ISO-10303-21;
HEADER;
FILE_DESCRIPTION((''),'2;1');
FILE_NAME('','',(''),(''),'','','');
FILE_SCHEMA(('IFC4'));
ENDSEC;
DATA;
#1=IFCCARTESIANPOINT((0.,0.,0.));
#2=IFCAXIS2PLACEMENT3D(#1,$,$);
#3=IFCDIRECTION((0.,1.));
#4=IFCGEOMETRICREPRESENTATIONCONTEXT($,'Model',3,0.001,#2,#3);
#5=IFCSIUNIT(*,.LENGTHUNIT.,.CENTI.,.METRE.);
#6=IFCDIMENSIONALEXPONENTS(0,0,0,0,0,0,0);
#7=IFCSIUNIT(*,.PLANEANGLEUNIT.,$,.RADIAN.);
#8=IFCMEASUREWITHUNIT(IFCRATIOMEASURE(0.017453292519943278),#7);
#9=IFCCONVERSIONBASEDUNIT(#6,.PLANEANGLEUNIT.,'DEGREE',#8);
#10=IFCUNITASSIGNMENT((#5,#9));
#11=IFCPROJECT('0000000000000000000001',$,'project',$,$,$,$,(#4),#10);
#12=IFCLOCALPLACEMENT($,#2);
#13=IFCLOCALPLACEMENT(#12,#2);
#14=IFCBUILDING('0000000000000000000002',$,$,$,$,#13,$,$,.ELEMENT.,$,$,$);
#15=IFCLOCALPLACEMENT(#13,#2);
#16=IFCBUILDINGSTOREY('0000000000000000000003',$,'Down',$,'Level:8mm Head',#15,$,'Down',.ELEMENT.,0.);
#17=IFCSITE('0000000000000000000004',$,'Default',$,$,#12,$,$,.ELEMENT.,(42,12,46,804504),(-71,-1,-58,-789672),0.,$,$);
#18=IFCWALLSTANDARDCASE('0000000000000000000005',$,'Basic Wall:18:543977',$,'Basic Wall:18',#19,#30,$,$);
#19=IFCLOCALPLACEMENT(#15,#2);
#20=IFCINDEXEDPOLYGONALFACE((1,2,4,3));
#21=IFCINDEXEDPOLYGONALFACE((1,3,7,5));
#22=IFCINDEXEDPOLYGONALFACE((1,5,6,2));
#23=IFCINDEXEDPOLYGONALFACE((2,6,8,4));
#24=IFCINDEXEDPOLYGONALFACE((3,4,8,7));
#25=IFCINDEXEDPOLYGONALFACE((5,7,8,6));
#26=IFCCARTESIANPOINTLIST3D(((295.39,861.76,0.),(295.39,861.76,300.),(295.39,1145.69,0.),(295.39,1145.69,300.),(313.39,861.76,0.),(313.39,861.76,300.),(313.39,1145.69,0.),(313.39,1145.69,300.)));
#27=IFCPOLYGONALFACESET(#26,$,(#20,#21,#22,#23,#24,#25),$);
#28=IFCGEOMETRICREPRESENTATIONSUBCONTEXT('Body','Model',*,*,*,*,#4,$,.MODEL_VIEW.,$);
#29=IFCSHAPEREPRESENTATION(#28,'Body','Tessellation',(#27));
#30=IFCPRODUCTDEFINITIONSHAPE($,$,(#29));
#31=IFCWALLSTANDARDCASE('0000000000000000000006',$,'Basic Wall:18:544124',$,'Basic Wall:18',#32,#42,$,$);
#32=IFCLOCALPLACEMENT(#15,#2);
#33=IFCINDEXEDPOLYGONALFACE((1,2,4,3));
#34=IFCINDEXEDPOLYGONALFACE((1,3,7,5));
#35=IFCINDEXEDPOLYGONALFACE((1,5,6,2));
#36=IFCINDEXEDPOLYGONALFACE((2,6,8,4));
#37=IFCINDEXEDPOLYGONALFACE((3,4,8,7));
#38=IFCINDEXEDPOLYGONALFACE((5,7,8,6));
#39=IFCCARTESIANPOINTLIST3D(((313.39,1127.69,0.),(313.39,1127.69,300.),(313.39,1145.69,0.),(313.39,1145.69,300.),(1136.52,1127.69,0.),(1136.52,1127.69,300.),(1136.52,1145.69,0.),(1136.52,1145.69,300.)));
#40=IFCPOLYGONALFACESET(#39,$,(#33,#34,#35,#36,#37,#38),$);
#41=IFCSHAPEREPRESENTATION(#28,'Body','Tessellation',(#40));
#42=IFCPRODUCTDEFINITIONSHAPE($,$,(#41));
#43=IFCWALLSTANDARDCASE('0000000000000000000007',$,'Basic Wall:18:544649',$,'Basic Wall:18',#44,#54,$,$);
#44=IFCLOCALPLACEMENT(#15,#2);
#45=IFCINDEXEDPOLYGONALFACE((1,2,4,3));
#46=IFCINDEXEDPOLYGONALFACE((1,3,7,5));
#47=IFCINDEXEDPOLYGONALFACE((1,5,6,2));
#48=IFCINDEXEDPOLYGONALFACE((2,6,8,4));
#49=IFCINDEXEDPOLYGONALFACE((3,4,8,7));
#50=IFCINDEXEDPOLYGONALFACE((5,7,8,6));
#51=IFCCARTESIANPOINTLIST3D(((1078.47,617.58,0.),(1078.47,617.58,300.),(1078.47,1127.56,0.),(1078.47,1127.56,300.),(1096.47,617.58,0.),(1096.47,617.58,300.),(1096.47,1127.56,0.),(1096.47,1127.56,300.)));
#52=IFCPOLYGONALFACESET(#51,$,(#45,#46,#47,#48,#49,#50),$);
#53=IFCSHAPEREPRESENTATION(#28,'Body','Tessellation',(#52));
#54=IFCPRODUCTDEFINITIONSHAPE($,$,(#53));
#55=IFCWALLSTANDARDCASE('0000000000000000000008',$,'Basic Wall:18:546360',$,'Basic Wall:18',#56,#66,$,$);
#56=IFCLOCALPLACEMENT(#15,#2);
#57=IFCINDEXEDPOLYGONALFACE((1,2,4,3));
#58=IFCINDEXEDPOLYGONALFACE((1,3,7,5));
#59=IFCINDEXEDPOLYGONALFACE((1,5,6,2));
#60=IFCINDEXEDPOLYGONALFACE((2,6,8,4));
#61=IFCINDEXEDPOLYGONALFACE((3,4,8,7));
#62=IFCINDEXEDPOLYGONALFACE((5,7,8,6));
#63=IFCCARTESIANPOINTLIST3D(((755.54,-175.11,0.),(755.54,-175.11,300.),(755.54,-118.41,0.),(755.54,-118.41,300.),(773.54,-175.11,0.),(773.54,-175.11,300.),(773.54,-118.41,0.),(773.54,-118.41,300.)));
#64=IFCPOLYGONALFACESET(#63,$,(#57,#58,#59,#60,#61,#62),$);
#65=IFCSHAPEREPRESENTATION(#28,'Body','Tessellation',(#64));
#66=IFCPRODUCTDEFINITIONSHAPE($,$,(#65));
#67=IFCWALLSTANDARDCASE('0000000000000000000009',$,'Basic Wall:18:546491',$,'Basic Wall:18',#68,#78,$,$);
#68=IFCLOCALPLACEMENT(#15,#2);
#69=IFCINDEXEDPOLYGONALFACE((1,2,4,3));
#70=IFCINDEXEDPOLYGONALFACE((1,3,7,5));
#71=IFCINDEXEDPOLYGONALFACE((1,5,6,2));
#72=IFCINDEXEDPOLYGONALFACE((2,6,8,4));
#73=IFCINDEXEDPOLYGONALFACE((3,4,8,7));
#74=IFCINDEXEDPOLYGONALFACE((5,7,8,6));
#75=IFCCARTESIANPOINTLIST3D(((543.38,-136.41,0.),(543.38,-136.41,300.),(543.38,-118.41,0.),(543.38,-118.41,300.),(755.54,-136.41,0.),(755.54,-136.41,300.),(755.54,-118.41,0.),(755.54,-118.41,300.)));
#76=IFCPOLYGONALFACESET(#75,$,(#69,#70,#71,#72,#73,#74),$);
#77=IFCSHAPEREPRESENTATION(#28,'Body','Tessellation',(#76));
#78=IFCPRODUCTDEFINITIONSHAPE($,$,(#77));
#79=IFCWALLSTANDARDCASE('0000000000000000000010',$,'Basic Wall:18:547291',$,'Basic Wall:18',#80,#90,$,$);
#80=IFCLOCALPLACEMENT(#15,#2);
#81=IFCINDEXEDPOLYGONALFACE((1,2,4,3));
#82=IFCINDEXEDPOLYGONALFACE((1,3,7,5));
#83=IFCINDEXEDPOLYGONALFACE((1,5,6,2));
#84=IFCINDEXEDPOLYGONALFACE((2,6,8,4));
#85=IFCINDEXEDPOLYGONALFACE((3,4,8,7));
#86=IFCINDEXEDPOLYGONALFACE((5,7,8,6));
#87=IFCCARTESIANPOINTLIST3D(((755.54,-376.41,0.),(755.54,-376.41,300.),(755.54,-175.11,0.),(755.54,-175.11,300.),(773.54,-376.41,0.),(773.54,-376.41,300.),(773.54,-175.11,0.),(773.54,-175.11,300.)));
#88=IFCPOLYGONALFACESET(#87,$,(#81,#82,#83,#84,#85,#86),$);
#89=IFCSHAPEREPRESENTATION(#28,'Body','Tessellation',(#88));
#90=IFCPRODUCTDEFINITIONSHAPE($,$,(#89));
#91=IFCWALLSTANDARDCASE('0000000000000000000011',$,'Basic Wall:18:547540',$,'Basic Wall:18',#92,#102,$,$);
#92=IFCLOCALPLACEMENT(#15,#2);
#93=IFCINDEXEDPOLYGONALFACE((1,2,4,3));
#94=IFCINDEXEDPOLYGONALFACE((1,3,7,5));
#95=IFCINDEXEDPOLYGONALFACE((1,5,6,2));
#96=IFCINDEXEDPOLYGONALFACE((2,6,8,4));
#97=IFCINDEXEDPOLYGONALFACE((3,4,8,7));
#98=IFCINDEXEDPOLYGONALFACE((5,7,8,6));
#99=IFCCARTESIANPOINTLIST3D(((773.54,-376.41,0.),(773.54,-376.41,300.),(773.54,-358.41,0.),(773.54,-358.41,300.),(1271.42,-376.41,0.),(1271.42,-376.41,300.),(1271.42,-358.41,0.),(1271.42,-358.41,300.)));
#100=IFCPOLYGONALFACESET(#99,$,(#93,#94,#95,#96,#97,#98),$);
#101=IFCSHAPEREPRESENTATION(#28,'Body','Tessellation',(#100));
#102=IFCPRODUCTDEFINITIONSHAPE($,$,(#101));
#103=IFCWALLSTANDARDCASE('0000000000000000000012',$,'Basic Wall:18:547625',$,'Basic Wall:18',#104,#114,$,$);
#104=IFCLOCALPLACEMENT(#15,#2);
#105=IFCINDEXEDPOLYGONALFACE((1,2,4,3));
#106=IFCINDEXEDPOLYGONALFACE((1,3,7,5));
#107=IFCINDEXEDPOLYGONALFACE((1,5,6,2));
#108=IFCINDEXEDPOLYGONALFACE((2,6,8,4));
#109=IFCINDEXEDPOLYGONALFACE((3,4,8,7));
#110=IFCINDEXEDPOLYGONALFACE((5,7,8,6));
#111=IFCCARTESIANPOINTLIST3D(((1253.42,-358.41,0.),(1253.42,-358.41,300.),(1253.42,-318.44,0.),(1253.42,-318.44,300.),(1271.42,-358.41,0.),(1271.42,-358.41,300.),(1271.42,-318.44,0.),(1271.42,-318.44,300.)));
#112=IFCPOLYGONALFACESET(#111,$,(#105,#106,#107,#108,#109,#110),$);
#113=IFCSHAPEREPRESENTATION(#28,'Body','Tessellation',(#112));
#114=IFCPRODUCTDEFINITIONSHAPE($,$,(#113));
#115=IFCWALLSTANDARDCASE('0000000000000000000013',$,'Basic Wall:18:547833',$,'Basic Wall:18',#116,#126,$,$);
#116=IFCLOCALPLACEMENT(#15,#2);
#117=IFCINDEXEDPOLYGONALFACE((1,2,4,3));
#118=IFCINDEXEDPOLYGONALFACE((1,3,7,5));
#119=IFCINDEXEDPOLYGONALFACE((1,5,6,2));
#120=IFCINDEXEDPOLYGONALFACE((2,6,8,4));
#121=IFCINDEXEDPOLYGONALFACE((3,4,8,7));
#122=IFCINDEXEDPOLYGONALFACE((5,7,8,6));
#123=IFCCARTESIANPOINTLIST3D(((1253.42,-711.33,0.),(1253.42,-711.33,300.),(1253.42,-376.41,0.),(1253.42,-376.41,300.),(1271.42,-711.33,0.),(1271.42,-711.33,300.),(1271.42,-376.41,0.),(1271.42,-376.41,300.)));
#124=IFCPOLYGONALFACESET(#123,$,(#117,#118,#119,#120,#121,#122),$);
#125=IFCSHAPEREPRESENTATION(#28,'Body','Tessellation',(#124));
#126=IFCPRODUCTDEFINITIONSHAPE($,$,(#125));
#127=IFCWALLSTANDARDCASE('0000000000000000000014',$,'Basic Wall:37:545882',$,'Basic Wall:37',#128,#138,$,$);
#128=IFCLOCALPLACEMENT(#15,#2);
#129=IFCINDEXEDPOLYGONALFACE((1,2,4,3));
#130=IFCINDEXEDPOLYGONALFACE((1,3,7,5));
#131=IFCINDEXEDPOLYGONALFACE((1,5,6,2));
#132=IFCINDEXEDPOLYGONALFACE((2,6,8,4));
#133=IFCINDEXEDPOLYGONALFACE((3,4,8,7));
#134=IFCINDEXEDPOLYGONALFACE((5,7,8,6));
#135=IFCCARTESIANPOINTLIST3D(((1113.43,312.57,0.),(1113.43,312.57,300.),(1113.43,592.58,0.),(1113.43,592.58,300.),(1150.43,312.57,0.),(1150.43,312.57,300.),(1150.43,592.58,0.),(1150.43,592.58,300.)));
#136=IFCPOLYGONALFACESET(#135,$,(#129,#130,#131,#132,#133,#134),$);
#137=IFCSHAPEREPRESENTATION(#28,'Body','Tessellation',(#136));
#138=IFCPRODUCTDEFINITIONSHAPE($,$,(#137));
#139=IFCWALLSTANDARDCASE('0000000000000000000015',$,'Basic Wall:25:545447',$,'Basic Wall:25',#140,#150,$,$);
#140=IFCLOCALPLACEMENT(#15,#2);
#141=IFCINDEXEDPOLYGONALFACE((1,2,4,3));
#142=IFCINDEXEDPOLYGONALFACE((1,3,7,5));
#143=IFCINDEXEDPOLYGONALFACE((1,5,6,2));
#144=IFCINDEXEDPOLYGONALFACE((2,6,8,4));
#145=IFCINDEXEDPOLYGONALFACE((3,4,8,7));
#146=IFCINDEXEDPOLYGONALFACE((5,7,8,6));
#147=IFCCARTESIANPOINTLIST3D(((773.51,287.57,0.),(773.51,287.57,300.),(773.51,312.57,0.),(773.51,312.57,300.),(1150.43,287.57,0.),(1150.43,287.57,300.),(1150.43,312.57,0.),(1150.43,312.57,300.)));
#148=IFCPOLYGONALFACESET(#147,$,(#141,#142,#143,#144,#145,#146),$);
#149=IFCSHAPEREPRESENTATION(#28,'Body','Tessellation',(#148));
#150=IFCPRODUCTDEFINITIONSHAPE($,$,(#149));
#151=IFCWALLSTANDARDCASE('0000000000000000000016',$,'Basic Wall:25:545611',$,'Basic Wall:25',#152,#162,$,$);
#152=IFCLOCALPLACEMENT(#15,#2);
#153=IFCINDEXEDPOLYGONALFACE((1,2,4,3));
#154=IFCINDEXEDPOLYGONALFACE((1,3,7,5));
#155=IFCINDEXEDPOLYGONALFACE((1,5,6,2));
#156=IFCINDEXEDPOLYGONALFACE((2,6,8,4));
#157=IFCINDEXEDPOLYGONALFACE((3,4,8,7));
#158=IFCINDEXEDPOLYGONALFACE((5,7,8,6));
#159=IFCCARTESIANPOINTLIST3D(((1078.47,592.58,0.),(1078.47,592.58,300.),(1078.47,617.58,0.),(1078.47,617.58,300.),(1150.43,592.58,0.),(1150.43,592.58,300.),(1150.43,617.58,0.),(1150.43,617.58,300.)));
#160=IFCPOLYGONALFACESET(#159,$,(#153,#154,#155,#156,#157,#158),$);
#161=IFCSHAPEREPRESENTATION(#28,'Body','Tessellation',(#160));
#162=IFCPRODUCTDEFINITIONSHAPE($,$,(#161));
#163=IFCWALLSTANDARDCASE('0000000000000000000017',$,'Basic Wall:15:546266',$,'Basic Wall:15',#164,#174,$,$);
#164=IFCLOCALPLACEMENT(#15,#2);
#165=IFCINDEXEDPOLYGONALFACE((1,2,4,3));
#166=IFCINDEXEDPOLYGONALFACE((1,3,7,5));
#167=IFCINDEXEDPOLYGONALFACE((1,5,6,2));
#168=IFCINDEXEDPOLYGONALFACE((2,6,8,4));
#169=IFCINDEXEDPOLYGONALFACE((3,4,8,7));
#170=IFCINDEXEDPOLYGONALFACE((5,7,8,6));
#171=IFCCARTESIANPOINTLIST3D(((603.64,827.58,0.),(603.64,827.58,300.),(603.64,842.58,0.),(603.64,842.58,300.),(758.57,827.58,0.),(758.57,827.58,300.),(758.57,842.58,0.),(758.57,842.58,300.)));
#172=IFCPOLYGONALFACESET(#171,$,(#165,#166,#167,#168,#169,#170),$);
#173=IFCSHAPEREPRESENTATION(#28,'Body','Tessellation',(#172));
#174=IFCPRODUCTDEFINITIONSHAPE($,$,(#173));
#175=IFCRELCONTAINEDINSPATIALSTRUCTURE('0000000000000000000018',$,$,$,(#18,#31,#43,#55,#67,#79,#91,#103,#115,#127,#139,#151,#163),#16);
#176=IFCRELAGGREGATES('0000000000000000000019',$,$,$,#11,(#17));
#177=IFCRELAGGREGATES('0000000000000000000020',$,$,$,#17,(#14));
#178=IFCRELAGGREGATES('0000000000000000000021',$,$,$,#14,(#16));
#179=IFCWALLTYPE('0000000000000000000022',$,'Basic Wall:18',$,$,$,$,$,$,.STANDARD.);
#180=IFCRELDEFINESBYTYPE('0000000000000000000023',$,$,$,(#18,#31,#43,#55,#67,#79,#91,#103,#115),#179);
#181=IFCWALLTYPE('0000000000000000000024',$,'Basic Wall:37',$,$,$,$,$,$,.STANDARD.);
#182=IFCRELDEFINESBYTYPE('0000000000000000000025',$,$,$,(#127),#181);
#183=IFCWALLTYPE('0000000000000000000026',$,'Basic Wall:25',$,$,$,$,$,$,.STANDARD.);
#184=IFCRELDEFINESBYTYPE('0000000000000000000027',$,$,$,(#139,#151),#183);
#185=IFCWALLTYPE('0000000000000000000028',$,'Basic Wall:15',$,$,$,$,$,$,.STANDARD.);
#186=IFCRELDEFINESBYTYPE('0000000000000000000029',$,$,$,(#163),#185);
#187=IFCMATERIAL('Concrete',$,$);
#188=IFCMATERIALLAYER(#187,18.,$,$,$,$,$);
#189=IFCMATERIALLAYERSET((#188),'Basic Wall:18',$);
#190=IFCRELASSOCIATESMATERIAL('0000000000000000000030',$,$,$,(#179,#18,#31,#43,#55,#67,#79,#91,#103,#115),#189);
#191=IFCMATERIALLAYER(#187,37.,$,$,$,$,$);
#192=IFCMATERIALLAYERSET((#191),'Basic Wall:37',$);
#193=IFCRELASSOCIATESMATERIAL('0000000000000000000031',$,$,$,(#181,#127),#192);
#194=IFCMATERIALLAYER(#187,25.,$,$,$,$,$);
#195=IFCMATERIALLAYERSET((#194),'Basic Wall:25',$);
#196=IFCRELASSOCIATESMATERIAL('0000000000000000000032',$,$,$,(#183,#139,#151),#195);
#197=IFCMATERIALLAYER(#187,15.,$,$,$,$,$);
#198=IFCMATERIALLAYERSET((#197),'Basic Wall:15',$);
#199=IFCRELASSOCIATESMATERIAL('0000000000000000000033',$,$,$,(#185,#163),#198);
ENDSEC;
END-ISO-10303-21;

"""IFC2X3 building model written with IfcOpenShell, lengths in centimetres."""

from ifc_helpers import new_model, entity, si_unit, converted_unit, direction, frame, frame_2d, origin, place, context, subcontext, project, spatial, rectangle, extrude, material, layer, layer_set, layer_usage, type_object, element, save


model = new_model("IFC2X3")

# Units and contexts
model_context = context("Model", 3, precision=0.001, world=origin(), true_north=direction((0.0, 1.0)))
body_context = subcontext(model_context, "Body", "Model", "MODEL_VIEW")
ifc_project = project(units=[si_unit("LENGTHUNIT", "METRE", prefix="CENTI"), converted_unit("PLANEANGLEUNIT", "DEGREE", entity("IfcRatioMeasure", 0.017453292519943278), si_unit("PLANEANGLEUNIT", "RADIAN"), dimensions=[0, 0, 0, 0, 0, 0, 0])], contexts=[model_context])

# Site, building, storey
site_placement = place(None, origin())
site = spatial("IfcSite", under=ifc_project, at=site_placement, Name="Default", CompositionType="ELEMENT", RefLatitude=(42, 12, 46, 804504), RefLongitude=(-71, -1, -58, -789672), RefElevation=0.0)
building_placement = place(site_placement, origin())
building = spatial("IfcBuilding", under=site, at=building_placement, CompositionType="ELEMENT")
storey_placement = place(building_placement, origin())
storey = spatial("IfcBuildingStorey", under=building, at=storey_placement, Name="Down", ObjectType="Level:8mm Head", LongName="Down", CompositionType="ELEMENT", Elevation=0.0)

# Walls
ifc_material = material(Name="Concrete")
ifc_layer_1 = layer(ifc_material, 18.0)
ifc_layer_set_1 = layer_set([ifc_layer_1], Name="Basic Wall:18")
wall_type_1 = type_object("IfcWallType", Name="Basic Wall:18", PredefinedType="STANDARD", material=ifc_layer_set_1)
ifc_layer_usage_1 = layer_usage(ifc_layer_set_1, "AXIS2", "POSITIVE", -9.0)
wall_1_placement = place(storey_placement, frame((304.39, 861.76, 0.0), z_axis=(0.0, 0.0, 1.0), x_axis=(0.0, 1.0, 0.0)))
element("IfcWallStandardCase", 1, at=wall_1_placement, inside=storey, type_object=wall_type_1, material=ifc_layer_usage_1, Name="Basic Wall:18:543977", ObjectType="Basic Wall:18", context=body_context, shape_type="SweptSolid", body=[
    extrude(rectangle(XDim=283.93, YDim=18.0, at=frame_2d((141.97, 0.0), x_axis=(-1.0, 0.0))), origin(), (0.0, 0.0, 1.0), 300.0),
])
ifc_layer_usage_2 = layer_usage(ifc_layer_set_1, "AXIS2", "NEGATIVE", 9.0)
wall_2_placement = place(storey_placement, frame((313.39, 1136.69, 0.0)))
element("IfcWallStandardCase", 2, at=wall_2_placement, inside=storey, type_object=wall_type_1, material=ifc_layer_usage_2, Name="Basic Wall:18:544124", ObjectType="Basic Wall:18", context=body_context, shape_type="SweptSolid", body=[
    extrude(rectangle(XDim=823.13, YDim=18.0, at=frame_2d((411.56, 0.0), x_axis=(-1.0, 0.0))), origin(), (0.0, 0.0, 1.0), 300.0),
])
ifc_layer_usage_3 = layer_usage(ifc_layer_set_1, "AXIS2", "NEGATIVE", 9.0)
wall_3_placement = place(storey_placement, frame((1087.47, 1127.56, 0.0), z_axis=(0.0, 0.0, 1.0), x_axis=(0.0, -1.0, 0.0)))
element("IfcWallStandardCase", 3, at=wall_3_placement, inside=storey, type_object=wall_type_1, material=ifc_layer_usage_3, Name="Basic Wall:18:544649", ObjectType="Basic Wall:18", context=body_context, shape_type="SweptSolid", body=[
    extrude(rectangle(XDim=509.98, YDim=18.0, at=frame_2d((254.99, 0.0), x_axis=(-1.0, 0.0))), origin(), (0.0, 0.0, 1.0), 300.0),
])
ifc_layer_usage_4 = layer_usage(ifc_layer_set_1, "AXIS2", "POSITIVE", -9.0)
wall_4_placement = place(storey_placement, frame((764.54, -175.11, 0.0), z_axis=(0.0, 0.0, 1.0), x_axis=(0.0, 1.0, 0.0)))
element("IfcWallStandardCase", 4, at=wall_4_placement, inside=storey, type_object=wall_type_1, material=ifc_layer_usage_4, Name="Basic Wall:18:546360", ObjectType="Basic Wall:18", context=body_context, shape_type="SweptSolid", body=[
    extrude(rectangle(XDim=56.7, YDim=18.0, at=frame_2d((28.35, 0.0), x_axis=(-1.0, 0.0))), origin(), (0.0, 0.0, 1.0), 300.0),
])
ifc_layer_usage_5 = layer_usage(ifc_layer_set_1, "AXIS2", "POSITIVE", -9.0)
wall_5_placement = place(storey_placement, frame((755.54, -127.41, 0.0), z_axis=(0.0, 0.0, 1.0), x_axis=(-1.0, 0.0, 0.0)))
element("IfcWallStandardCase", 5, at=wall_5_placement, inside=storey, type_object=wall_type_1, material=ifc_layer_usage_5, Name="Basic Wall:18:546491", ObjectType="Basic Wall:18", context=body_context, shape_type="SweptSolid", body=[
    extrude(rectangle(XDim=212.16, YDim=18.0, at=frame_2d((106.08, 0.0), x_axis=(-1.0, 0.0))), origin(), (0.0, 0.0, 1.0), 300.0),
])
ifc_layer_usage_6 = layer_usage(ifc_layer_set_1, "AXIS2", "NEGATIVE", 9.0)
wall_6_placement = place(storey_placement, frame((764.54, -175.11, 0.0), z_axis=(0.0, 0.0, 1.0), x_axis=(0.0, -1.0, 0.0)))
element("IfcWallStandardCase", 6, at=wall_6_placement, inside=storey, type_object=wall_type_1, material=ifc_layer_usage_6, Name="Basic Wall:18:547291", ObjectType="Basic Wall:18", context=body_context, shape_type="SweptSolid", body=[
    extrude(rectangle(XDim=201.3, YDim=18.0, at=frame_2d((100.65, 0.0), x_axis=(-1.0, 0.0))), origin(), (0.0, 0.0, 1.0), 300.0),
])
ifc_layer_usage_7 = layer_usage(ifc_layer_set_1, "AXIS2", "POSITIVE", -9.0)
wall_7_placement = place(storey_placement, frame((773.54, -367.41, 0.0)))
element("IfcWallStandardCase", 7, at=wall_7_placement, inside=storey, type_object=wall_type_1, material=ifc_layer_usage_7, Name="Basic Wall:18:547540", ObjectType="Basic Wall:18", context=body_context, shape_type="SweptSolid", body=[
    extrude(rectangle(XDim=497.88, YDim=18.0, at=frame_2d((248.94, 0.0), x_axis=(-1.0, 0.0))), origin(), (0.0, 0.0, 1.0), 300.0),
])
ifc_layer_usage_8 = layer_usage(ifc_layer_set_1, "AXIS2", "POSITIVE", -9.0)
wall_8_placement = place(storey_placement, frame((1262.42, -358.41, 0.0), z_axis=(0.0, 0.0, 1.0), x_axis=(0.0, 1.0, 0.0)))
element("IfcWallStandardCase", 8, at=wall_8_placement, inside=storey, type_object=wall_type_1, material=ifc_layer_usage_8, Name="Basic Wall:18:547625", ObjectType="Basic Wall:18", context=body_context, shape_type="SweptSolid", body=[
    extrude(rectangle(XDim=39.97, YDim=18.0, at=frame_2d((19.98, 0.0), x_axis=(-1.0, 0.0))), origin(), (0.0, 0.0, 1.0), 300.0),
])
ifc_layer_usage_9 = layer_usage(ifc_layer_set_1, "AXIS2", "NEGATIVE", 9.0)
wall_9_placement = place(storey_placement, frame((1262.42, -376.41, 0.0), z_axis=(0.0, 0.0, 1.0), x_axis=(0.0, -1.0, 0.0)))
element("IfcWallStandardCase", 9, at=wall_9_placement, inside=storey, type_object=wall_type_1, material=ifc_layer_usage_9, Name="Basic Wall:18:547833", ObjectType="Basic Wall:18", context=body_context, shape_type="SweptSolid", body=[
    extrude(rectangle(XDim=334.92, YDim=18.0, at=frame_2d((167.46, 0.0), x_axis=(-1.0, 0.0))), origin(), (0.0, 0.0, 1.0), 300.0),
])
ifc_layer_2 = layer(ifc_material, 37.0)
ifc_layer_set_2 = layer_set([ifc_layer_2], Name="Basic Wall:37")
ifc_layer_usage_10 = layer_usage(ifc_layer_set_2, "AXIS2", "NEGATIVE", 18.5)
wall_type_2 = type_object("IfcWallType", Name="Basic Wall:37", PredefinedType="STANDARD", material=ifc_layer_set_2)
wall_10_placement = place(storey_placement, frame((1131.93, 592.58, 0.0), z_axis=(0.0, 0.0, 1.0), x_axis=(0.0, -1.0, 0.0)))
element("IfcWallStandardCase", 10, at=wall_10_placement, inside=storey, type_object=wall_type_2, material=ifc_layer_usage_10, Name="Basic Wall:37:545882", ObjectType="Basic Wall:37", context=body_context, shape_type="SweptSolid", body=[
    extrude(rectangle(XDim=280.01, YDim=37.0, at=frame_2d((140.01, 0.0), x_axis=(-1.0, 0.0))), origin(), (0.0, 0.0, 1.0), 300.0),
])
ifc_layer_3 = layer(ifc_material, 25.0)
ifc_layer_set_3 = layer_set([ifc_layer_3], Name="Basic Wall:25")
ifc_layer_usage_11 = layer_usage(ifc_layer_set_3, "AXIS2", "POSITIVE", -12.5)
wall_type_3 = type_object("IfcWallType", Name="Basic Wall:25", PredefinedType="STANDARD", material=ifc_layer_set_3)
wall_11_placement = place(storey_placement, frame((773.51, 300.07, 0.0)))
element("IfcWallStandardCase", 11, at=wall_11_placement, inside=storey, type_object=wall_type_3, material=ifc_layer_usage_11, Name="Basic Wall:25:545447", ObjectType="Basic Wall:25", context=body_context, shape_type="SweptSolid", body=[
    extrude(rectangle(XDim=376.91, YDim=25.0, at=frame_2d((188.46, 0.0), x_axis=(-1.0, 0.0))), origin(), (0.0, 0.0, 1.0), 300.0),
])
ifc_layer_usage_12 = layer_usage(ifc_layer_set_3, "AXIS2", "POSITIVE", -12.5)
wall_12_placement = place(storey_placement, frame((1078.47, 605.08, 0.0)))
element("IfcWallStandardCase", 12, at=wall_12_placement, inside=storey, type_object=wall_type_3, material=ifc_layer_usage_12, Name="Basic Wall:25:545611", ObjectType="Basic Wall:25", context=body_context, shape_type="SweptSolid", body=[
    extrude(rectangle(XDim=71.96, YDim=25.0, at=frame_2d((35.98, 0.0), x_axis=(-1.0, 0.0))), origin(), (0.0, 0.0, 1.0), 300.0),
])
ifc_layer_4 = layer(ifc_material, 15.0)
ifc_layer_set_4 = layer_set([ifc_layer_4], Name="Basic Wall:15")
ifc_layer_usage_13 = layer_usage(ifc_layer_set_4, "AXIS2", "NEGATIVE", 7.5)
wall_type_4 = type_object("IfcWallType", Name="Basic Wall:15", PredefinedType="STANDARD", material=ifc_layer_set_4)
wall_13_placement = place(storey_placement, frame((603.64, 835.08, 0.0)))
element("IfcWallStandardCase", 13, at=wall_13_placement, inside=storey, type_object=wall_type_4, material=ifc_layer_usage_13, Name="Basic Wall:15:546266", ObjectType="Basic Wall:15", context=body_context, shape_type="SweptSolid", body=[
    extrude(rectangle(XDim=154.93, YDim=15.0, at=frame_2d((77.46, 0.0), x_axis=(-1.0, 0.0))), origin(), (0.0, 0.0, 1.0), 300.0),
])

save(model, "model.ifc")
